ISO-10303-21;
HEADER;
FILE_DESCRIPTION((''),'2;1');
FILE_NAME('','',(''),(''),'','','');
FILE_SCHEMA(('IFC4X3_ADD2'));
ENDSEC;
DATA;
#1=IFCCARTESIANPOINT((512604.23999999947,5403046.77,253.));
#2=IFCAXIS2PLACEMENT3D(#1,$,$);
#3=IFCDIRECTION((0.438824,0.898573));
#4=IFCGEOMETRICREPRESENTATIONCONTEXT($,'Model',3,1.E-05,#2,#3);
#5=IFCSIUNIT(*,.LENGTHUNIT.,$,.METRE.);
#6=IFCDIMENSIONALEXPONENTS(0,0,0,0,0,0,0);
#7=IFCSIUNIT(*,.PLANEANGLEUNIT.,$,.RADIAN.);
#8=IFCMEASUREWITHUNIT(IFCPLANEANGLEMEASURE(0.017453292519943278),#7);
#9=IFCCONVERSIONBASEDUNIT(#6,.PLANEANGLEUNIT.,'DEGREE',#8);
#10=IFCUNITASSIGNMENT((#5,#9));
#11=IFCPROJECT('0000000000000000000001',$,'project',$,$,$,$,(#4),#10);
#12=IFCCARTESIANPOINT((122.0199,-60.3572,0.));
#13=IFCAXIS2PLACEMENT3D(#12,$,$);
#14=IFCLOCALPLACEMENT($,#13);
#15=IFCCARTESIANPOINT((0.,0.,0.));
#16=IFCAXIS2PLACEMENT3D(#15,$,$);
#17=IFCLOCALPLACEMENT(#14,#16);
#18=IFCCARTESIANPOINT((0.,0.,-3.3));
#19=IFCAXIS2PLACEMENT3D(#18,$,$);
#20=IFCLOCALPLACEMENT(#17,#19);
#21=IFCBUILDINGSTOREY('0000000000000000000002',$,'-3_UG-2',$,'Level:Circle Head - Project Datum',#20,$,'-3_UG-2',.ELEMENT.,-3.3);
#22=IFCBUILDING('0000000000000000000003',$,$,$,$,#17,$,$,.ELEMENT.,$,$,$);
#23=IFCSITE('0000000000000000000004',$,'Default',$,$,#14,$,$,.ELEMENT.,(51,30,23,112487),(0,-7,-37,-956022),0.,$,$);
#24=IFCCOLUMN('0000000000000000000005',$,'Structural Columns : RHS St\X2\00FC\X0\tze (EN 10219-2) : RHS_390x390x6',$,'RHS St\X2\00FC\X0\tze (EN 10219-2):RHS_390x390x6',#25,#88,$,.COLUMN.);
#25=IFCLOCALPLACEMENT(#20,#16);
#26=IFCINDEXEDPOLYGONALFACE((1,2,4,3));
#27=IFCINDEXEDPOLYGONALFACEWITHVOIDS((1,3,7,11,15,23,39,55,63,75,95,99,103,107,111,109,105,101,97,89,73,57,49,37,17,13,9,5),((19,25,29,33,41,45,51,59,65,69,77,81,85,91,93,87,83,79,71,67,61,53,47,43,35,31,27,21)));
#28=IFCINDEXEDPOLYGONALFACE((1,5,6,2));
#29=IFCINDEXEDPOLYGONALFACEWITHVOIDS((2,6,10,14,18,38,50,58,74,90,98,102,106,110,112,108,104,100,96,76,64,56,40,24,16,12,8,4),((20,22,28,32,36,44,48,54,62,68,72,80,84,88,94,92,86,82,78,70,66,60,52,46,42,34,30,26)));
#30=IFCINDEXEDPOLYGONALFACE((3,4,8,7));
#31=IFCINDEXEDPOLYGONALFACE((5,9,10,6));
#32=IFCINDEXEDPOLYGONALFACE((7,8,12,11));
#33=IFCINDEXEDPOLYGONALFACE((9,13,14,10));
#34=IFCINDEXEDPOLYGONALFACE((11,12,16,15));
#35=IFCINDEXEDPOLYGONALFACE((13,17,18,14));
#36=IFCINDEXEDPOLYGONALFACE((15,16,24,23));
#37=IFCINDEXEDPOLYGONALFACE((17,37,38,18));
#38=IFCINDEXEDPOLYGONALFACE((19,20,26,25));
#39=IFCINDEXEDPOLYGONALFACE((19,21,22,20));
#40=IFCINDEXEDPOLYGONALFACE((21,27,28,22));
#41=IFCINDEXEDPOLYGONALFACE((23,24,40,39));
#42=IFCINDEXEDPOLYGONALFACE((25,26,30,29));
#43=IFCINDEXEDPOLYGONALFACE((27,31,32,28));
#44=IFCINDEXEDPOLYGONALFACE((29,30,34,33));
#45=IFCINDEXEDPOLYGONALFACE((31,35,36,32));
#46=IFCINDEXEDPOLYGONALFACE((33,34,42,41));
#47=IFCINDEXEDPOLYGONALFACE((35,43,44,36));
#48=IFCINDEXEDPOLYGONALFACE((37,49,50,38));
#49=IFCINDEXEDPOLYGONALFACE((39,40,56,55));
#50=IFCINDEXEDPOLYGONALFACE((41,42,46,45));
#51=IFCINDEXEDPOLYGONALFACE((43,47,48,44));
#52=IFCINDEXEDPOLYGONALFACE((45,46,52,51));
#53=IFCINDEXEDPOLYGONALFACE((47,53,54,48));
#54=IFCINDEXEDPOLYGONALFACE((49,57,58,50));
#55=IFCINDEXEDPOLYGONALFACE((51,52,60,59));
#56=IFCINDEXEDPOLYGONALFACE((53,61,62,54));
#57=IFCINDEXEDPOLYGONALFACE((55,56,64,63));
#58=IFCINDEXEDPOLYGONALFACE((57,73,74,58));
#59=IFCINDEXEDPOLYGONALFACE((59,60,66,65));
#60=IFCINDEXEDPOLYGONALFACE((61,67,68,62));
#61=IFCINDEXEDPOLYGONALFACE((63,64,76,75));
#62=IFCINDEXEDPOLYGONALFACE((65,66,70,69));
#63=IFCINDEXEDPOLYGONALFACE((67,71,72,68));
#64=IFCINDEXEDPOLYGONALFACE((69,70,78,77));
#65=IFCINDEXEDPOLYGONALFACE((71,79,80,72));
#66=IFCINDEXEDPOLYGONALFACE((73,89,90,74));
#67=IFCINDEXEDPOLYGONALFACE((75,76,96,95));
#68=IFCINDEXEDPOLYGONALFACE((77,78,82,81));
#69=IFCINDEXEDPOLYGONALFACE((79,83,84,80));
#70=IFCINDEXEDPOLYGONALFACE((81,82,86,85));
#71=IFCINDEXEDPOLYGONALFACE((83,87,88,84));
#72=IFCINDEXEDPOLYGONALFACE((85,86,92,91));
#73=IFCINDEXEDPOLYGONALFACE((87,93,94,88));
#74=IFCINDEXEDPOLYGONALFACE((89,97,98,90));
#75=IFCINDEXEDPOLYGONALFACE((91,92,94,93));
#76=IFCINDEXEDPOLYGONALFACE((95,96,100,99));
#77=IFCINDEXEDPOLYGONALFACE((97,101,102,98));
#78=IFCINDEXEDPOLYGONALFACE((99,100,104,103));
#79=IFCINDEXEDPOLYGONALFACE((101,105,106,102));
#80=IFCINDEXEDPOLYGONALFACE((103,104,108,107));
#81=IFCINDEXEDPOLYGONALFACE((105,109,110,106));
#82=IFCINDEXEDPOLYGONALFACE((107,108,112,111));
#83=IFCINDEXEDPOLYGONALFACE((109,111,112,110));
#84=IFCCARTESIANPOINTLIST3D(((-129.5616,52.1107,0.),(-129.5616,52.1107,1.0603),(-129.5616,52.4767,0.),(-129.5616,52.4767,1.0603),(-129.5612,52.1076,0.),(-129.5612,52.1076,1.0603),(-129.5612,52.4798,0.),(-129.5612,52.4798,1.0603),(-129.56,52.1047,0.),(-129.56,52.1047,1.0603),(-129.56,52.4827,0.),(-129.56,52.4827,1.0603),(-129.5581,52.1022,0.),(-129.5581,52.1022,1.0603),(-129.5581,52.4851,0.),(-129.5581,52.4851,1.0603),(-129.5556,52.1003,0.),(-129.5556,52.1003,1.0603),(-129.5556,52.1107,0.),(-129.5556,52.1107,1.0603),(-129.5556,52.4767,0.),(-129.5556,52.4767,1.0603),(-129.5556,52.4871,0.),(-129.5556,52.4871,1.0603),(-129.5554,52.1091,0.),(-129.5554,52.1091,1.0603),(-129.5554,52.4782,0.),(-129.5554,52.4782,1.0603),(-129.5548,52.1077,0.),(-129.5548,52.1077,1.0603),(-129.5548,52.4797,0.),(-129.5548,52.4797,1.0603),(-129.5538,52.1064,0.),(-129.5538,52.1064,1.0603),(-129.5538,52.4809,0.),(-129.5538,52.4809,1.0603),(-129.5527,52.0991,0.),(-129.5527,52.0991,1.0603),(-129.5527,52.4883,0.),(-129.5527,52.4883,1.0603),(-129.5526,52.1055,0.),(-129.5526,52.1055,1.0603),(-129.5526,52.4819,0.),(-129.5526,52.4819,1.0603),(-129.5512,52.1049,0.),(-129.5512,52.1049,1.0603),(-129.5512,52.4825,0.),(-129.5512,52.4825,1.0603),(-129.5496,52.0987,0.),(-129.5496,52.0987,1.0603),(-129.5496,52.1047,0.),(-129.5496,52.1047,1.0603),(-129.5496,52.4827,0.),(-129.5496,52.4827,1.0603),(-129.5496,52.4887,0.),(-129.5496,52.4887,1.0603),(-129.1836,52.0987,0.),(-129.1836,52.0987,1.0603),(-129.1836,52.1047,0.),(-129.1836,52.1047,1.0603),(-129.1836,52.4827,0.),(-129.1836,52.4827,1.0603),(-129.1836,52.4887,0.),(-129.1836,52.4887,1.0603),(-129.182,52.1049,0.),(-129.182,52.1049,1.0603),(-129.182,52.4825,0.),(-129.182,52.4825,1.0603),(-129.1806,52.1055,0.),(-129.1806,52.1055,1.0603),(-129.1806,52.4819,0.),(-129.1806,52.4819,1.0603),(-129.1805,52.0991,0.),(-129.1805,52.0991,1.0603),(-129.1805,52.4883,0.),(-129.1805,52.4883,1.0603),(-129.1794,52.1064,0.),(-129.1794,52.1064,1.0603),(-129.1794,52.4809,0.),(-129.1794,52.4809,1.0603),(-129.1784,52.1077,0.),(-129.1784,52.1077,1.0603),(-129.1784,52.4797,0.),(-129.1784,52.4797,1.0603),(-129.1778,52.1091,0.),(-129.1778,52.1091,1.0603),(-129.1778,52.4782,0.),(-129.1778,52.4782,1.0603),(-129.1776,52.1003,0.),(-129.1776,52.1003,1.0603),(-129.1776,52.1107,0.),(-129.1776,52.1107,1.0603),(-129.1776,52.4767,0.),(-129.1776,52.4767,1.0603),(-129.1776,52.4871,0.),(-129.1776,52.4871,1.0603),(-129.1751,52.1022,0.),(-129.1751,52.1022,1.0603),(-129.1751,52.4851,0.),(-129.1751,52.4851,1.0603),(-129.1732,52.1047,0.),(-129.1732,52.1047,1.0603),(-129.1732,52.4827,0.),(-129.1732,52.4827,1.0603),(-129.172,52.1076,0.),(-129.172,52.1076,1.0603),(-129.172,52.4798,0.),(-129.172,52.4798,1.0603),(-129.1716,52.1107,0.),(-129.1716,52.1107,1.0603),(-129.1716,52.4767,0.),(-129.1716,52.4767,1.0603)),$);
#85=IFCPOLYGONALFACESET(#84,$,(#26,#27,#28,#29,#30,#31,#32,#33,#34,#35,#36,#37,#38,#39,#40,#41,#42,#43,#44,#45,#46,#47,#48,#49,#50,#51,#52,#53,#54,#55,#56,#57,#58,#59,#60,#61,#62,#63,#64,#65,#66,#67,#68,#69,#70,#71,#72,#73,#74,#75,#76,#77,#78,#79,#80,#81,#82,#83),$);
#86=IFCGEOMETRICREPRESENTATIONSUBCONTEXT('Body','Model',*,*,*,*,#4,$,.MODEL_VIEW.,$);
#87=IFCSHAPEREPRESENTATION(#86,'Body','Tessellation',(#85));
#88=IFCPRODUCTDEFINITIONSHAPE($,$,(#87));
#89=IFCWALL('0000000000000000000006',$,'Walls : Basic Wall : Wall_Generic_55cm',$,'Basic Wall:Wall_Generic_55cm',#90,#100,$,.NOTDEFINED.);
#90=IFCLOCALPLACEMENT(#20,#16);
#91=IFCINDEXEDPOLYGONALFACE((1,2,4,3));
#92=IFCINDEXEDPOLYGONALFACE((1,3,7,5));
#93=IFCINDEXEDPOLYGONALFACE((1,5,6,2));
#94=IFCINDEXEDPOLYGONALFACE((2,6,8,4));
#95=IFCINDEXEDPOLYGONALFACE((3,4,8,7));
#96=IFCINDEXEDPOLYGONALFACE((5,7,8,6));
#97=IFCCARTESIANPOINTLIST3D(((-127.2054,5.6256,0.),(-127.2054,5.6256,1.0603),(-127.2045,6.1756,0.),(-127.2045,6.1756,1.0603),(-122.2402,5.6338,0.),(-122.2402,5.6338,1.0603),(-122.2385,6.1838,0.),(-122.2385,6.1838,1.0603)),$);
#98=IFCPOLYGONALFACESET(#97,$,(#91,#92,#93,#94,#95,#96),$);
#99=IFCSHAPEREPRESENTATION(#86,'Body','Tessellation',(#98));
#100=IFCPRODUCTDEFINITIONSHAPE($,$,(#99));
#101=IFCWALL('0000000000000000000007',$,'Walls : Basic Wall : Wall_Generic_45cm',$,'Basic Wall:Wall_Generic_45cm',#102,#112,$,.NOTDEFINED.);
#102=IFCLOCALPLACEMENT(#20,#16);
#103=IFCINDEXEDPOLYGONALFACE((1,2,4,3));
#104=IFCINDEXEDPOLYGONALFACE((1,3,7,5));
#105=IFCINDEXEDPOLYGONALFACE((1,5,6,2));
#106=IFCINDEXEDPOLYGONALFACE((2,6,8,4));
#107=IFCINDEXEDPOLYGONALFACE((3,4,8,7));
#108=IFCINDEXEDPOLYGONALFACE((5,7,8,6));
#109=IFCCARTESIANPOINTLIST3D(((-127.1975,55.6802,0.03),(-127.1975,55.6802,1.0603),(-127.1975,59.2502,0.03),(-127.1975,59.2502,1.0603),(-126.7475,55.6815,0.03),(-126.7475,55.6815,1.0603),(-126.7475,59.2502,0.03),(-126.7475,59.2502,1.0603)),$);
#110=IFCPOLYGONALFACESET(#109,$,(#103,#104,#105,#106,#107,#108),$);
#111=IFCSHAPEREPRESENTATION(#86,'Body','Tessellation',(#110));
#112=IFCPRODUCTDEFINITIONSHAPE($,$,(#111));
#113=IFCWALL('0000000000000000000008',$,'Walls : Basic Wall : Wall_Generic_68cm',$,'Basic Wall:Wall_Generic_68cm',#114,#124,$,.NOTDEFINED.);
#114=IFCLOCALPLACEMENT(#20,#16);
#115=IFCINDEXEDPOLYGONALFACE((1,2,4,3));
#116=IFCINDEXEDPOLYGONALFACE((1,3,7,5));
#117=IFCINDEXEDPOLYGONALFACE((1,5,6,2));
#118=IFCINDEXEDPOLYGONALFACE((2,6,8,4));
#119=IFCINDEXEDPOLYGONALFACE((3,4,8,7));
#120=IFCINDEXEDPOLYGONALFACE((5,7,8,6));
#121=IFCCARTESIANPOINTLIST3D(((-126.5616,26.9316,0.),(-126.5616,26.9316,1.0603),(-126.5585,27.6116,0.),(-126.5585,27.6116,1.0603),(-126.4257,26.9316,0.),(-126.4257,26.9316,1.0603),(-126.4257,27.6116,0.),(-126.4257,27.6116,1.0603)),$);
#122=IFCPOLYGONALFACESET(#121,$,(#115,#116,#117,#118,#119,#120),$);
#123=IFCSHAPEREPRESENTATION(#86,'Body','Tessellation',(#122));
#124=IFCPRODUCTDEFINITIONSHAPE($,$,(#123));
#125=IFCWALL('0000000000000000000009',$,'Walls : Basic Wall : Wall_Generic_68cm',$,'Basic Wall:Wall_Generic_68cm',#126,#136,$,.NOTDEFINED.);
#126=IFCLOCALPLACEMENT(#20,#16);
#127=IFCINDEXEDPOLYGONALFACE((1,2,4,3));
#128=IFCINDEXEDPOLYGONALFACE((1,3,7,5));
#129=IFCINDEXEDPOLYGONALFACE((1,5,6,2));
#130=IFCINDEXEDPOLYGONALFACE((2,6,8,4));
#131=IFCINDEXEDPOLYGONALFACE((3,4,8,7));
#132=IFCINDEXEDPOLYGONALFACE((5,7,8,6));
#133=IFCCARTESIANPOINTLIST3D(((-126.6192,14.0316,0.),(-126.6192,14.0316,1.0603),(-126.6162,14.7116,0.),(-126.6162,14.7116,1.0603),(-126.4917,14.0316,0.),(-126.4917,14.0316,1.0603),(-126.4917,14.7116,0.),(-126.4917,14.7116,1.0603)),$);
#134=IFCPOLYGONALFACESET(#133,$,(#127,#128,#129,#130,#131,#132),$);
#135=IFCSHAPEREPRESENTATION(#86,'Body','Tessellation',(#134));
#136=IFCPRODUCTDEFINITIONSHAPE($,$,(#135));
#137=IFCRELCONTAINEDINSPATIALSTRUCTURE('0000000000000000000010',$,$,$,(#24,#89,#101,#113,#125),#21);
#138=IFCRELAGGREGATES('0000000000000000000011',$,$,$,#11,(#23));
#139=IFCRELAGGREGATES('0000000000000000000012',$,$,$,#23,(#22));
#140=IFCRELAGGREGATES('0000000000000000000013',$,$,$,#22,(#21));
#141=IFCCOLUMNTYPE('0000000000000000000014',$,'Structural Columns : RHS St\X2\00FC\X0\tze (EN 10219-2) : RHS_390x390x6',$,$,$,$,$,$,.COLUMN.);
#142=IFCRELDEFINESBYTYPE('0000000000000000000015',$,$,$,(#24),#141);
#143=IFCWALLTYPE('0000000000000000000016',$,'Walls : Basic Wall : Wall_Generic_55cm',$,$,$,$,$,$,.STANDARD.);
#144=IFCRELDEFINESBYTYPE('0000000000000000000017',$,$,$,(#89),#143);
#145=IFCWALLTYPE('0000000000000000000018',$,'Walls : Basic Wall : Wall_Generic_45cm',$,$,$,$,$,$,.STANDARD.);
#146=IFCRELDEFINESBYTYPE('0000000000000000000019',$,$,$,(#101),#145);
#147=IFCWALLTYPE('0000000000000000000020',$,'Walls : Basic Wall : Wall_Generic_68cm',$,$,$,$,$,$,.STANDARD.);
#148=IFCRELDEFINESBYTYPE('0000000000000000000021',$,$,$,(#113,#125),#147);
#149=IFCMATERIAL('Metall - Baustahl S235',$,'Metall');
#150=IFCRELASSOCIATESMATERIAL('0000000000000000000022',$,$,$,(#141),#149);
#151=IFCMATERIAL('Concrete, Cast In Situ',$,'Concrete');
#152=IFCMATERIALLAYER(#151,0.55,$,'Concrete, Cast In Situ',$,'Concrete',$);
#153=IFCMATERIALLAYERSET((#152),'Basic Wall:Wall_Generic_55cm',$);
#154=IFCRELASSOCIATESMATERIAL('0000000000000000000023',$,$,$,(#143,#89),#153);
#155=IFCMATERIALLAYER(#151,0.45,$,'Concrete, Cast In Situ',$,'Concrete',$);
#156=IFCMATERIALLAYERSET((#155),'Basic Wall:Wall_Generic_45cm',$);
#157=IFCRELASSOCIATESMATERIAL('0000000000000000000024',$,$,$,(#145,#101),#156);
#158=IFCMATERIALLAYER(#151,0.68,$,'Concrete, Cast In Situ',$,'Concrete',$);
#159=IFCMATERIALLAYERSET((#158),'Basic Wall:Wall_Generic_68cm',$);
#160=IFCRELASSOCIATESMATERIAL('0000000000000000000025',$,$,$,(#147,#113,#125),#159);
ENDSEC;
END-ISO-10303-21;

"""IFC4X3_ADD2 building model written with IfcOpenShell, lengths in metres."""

from ifc_helpers import new_model, entity, si_unit, converted_unit, direction, frame, frame_2d, origin, place, context, subcontext, project, spatial, polyline, circle_curve, parameter, trimmed, segment, composite_curve, outline, extrude, clip, halfspace, source, transform, mapped, material, layer, layer_set, material_profile, profile_set, type_object, type_shapes, element, save


model = new_model("IFC4X3_ADD2")

# Units and contexts
model_context = context("Model", 3, precision=1e-05, world=frame((512604.23999999947, 5403046.77, 253.0)), true_north=direction((0.438824, 0.898573)))
body_context = subcontext(model_context, "Body", "Model", "MODEL_VIEW")
ifc_project = project(units=[si_unit("LENGTHUNIT", "METRE"), converted_unit("PLANEANGLEUNIT", "DEGREE", entity("IfcPlaneAngleMeasure", 0.017453292519943278), si_unit("PLANEANGLEUNIT", "RADIAN"), dimensions=[0, 0, 0, 0, 0, 0, 0])], contexts=[model_context])

# Site, building, storey
site_placement = place(None, frame((122.0199, -60.3572, 0.0)))
site = spatial("IfcSite", under=ifc_project, at=site_placement, Name="Default", CompositionType="ELEMENT", RefLatitude=(51, 30, 23, 112487), RefLongitude=(0, -7, -37, -956022), RefElevation=0.0)
building_placement = place(site_placement, origin())
building = spatial("IfcBuilding", under=site, at=building_placement, CompositionType="ELEMENT")
storey_placement = place(building_placement, frame((0.0, 0.0, -3.3)))
storey = spatial("IfcBuildingStorey", under=building, at=storey_placement, Name="-3_UG-2", ObjectType="Level:Circle Head - Project Datum", LongName="-3_UG-2", CompositionType="ELEMENT", Elevation=-3.3)

# Column
ifc_material_1 = material(Name="Metall - Baustahl S235", Category="Metall")
ifc_material_profile_1 = material_profile(ifc_material_1, outline(composite_curve([segment(polyline([(-0.183, -0.195), (0.183, -0.195)]), True, "CONTINUOUS"), segment(trimmed(circle_curve(frame_2d((0.183, -0.183), x_axis=(-1.0, 0.0)), 0.012), [parameter(90.0)], [parameter(180.0)], True, "PARAMETER"), True, "CONTINUOUS"), segment(polyline([(0.195, -0.183), (0.195, 0.183)]), True, "CONTINUOUS"), segment(trimmed(circle_curve(frame_2d((0.183, 0.183), x_axis=(-1.0, 0.0)), 0.012), [parameter(180.0)], [parameter(270.0)], True, "PARAMETER"), True, "CONTINUOUS"), segment(polyline([(0.183, 0.195), (-0.183, 0.195)]), True, "CONTINUOUS"), segment(trimmed(circle_curve(frame_2d((-0.183, 0.183), x_axis=(-1.0, 0.0)), 0.012), [parameter(270.0)], [parameter(360.0)], True, "PARAMETER"), True, "CONTINUOUS"), segment(polyline([(-0.195, 0.183), (-0.195, -0.183)]), True, "CONTINUOUS"), segment(trimmed(circle_curve(frame_2d((-0.183, -0.183), x_axis=(-1.0, 0.0)), 0.012), [parameter(360.0)], [parameter(90.0)], True, "PARAMETER"), True, "CONTINUOUS")], self_intersect=False), holes=[composite_curve([segment(trimmed(circle_curve(frame_2d((-0.183, -0.183), x_axis=(-1.0, 0.0)), 0.006), [parameter(0.0)], [parameter(90.0)], True, "PARAMETER"), False, "CONTINUOUS"), segment(polyline([(-0.189, -0.183), (-0.189, 0.183)]), True, "CONTINUOUS"), segment(trimmed(circle_curve(frame_2d((-0.183, 0.183), x_axis=(-1.0, 0.0)), 0.006), [parameter(270.0)], [parameter(0.0)], True, "PARAMETER"), False, "CONTINUOUS"), segment(polyline([(-0.183, 0.189), (0.183, 0.189)]), True, "CONTINUOUS"), segment(trimmed(circle_curve(frame_2d((0.183, 0.183), x_axis=(-1.0, 0.0)), 0.006), [parameter(180.0)], [parameter(270.0)], True, "PARAMETER"), False, "CONTINUOUS"), segment(polyline([(0.189, 0.183), (0.189, -0.183)]), True, "CONTINUOUS"), segment(trimmed(circle_curve(frame_2d((0.183, -0.183), x_axis=(-1.0, 0.0)), 0.006), [parameter(90.0)], [parameter(180.0)], True, "PARAMETER"), False, "CONTINUOUS"), segment(polyline([(0.183, -0.189), (-0.183, -0.189)]), True, "CONTINUOUS")], self_intersect=False)]), Name="RHS_390x390x6")
ifc_profile_set_1 = profile_set([ifc_material_profile_1], Name="RHS_390x390x6")
column_type_1 = type_object("IfcColumnType", Name="Structural Columns : RHS Stütze (EN 10219-2) : RHS_390x390x6", PredefinedType="COLUMN", material=ifc_profile_set_1)
shared_shape_1 = source(origin(), body_context, "Body", "SweptSolid", [
    extrude(outline(composite_curve([segment(polyline([(-0.183, -0.195), (0.183, -0.195)]), True, "CONTINUOUS"), segment(trimmed(circle_curve(frame_2d((0.183, -0.183), x_axis=(-1.0, 0.0)), 0.012), [parameter(90.0)], [parameter(180.0)], True, "PARAMETER"), True, "CONTINUOUS"), segment(polyline([(0.195, -0.183), (0.195, 0.183)]), True, "CONTINUOUS"), segment(trimmed(circle_curve(frame_2d((0.183, 0.183), x_axis=(-1.0, 0.0)), 0.012), [parameter(180.0)], [parameter(270.0)], True, "PARAMETER"), True, "CONTINUOUS"), segment(polyline([(0.183, 0.195), (-0.183, 0.195)]), True, "CONTINUOUS"), segment(trimmed(circle_curve(frame_2d((-0.183, 0.183), x_axis=(-1.0, 0.0)), 0.012), [parameter(270.0)], [parameter(360.0)], True, "PARAMETER"), True, "CONTINUOUS"), segment(polyline([(-0.195, 0.183), (-0.195, -0.183)]), True, "CONTINUOUS"), segment(trimmed(circle_curve(frame_2d((-0.183, -0.183), x_axis=(-1.0, 0.0)), 0.012), [parameter(360.0)], [parameter(90.0)], True, "PARAMETER"), True, "CONTINUOUS")], self_intersect=False), holes=[composite_curve([segment(trimmed(circle_curve(frame_2d((-0.183, -0.183), x_axis=(-1.0, 0.0)), 0.006), [parameter(0.0)], [parameter(90.0)], True, "PARAMETER"), False, "CONTINUOUS"), segment(polyline([(-0.189, -0.183), (-0.189, 0.183)]), True, "CONTINUOUS"), segment(trimmed(circle_curve(frame_2d((-0.183, 0.183), x_axis=(-1.0, 0.0)), 0.006), [parameter(270.0)], [parameter(0.0)], True, "PARAMETER"), False, "CONTINUOUS"), segment(polyline([(-0.183, 0.189), (0.183, 0.189)]), True, "CONTINUOUS"), segment(trimmed(circle_curve(frame_2d((0.183, 0.183), x_axis=(-1.0, 0.0)), 0.006), [parameter(180.0)], [parameter(270.0)], True, "PARAMETER"), False, "CONTINUOUS"), segment(polyline([(0.189, 0.183), (0.189, -0.183)]), True, "CONTINUOUS"), segment(trimmed(circle_curve(frame_2d((0.183, -0.183), x_axis=(-1.0, 0.0)), 0.006), [parameter(90.0)], [parameter(180.0)], True, "PARAMETER"), False, "CONTINUOUS"), segment(polyline([(0.183, -0.189), (-0.183, -0.189)]), True, "CONTINUOUS")], self_intersect=False)]), frame((0.0, 0.0, -3.3), z_axis=(0.0, 0.0, 1.0), x_axis=(-1.0, 0.0, 0.0)), (0.0, 0.0, 1.0), 1.0603),
])
type_shapes(column_type_1, [shared_shape_1])
column_1_placement = place(storey_placement, frame((-129.3666, 52.2937, 3.3)))
element("IfcColumn", 1, at=column_1_placement, inside=storey, type_object=column_type_1, Name="Structural Columns : RHS Stütze (EN 10219-2) : RHS_390x390x6", ObjectType="RHS Stütze (EN 10219-2):RHS_390x390x6", PredefinedType="COLUMN", context=body_context, shape_type="MappedRepresentation", body=[
    mapped(shared_shape_1, transform((0.0, 0.0, 0.0), scale=1.0)),
])

# Walls
ifc_material_2 = material(Name="Concrete, Cast In Situ", Category="Concrete")
ifc_layer_1 = layer(ifc_material_2, 0.55, Name="Concrete, Cast In Situ", Category="Concrete")
ifc_layer_set_1 = layer_set([ifc_layer_1], Name="Basic Wall:Wall_Generic_55cm")
wall_type_1 = type_object("IfcWallType", Name="Walls : Basic Wall : Wall_Generic_55cm", PredefinedType="STANDARD", material=ifc_layer_set_1)
wall_1_placement = place(storey_placement, frame((-127.2058, 5.9006, 0.0), z_axis=(0.0, 0.0, 1.0), x_axis=(0.999999, 0.001649, 0.0)))
element("IfcWall", 2, at=wall_1_placement, inside=storey, type_object=wall_type_1, material=ifc_layer_set_1, Name="Walls : Basic Wall : Wall_Generic_55cm", ObjectType="Basic Wall:Wall_Generic_55cm", PredefinedType="NOTDEFINED", context=body_context, shape_type="Clipping", body=[
    clip(extrude(outline(polyline([(4.9652, -0.275), (4.9678, 0.275), (0.3368, 0.275), (0.0017, 0.275), (0.0, -0.275), (4.9652, -0.275)])), origin(), (0.0, 0.0, 1.0), 1.0603), halfspace(origin(), True)),
])
ifc_layer_2 = layer(ifc_material_2, 0.45, Name="Concrete, Cast In Situ", Category="Concrete")
ifc_layer_set_2 = layer_set([ifc_layer_2], Name="Basic Wall:Wall_Generic_45cm")
wall_type_2 = type_object("IfcWallType", Name="Walls : Basic Wall : Wall_Generic_45cm", PredefinedType="STANDARD", material=ifc_layer_set_2)
wall_2_placement = place(storey_placement, frame((-126.9725, 59.2502, 0.03), z_axis=(0.0, 0.0, 1.0), x_axis=(0.0, -1.0, 0.0)))
element("IfcWall", 3, at=wall_2_placement, inside=storey, type_object=wall_type_2, material=ifc_layer_set_2, Name="Walls : Basic Wall : Wall_Generic_45cm", ObjectType="Basic Wall:Wall_Generic_45cm", PredefinedType="NOTDEFINED", context=body_context, shape_type="Clipping", body=[
    clip(extrude(outline(polyline([(3.5701, -0.225), (3.5687, 0.225), (0.0, 0.225), (0.0, -0.225), (3.5701, -0.225)])), origin(), (0.0, 0.0, 1.0), 1.0303), halfspace(origin(), True)),
])
ifc_layer_3 = layer(ifc_material_2, 0.68, Name="Concrete, Cast In Situ", Category="Concrete")
ifc_layer_set_3 = layer_set([ifc_layer_3], Name="Basic Wall:Wall_Generic_68cm")
wall_type_3 = type_object("IfcWallType", Name="Walls : Basic Wall : Wall_Generic_68cm", PredefinedType="STANDARD", material=ifc_layer_set_3)
wall_3_placement = place(storey_placement, frame((-126.5616, 27.2716, 0.0)))
element("IfcWall", 4, at=wall_3_placement, inside=storey, type_object=wall_type_3, material=ifc_layer_set_3, Name="Walls : Basic Wall : Wall_Generic_68cm", ObjectType="Basic Wall:Wall_Generic_68cm", PredefinedType="NOTDEFINED", context=body_context, shape_type="Clipping", body=[
    clip(extrude(outline(polyline([(0.1359, -0.34), (0.1359, 0.34), (0.003, 0.34), (0.0, -0.34), (0.1359, -0.34)])), origin(), (0.0, 0.0, 1.0), 1.0603), halfspace(origin(), True)),
])
wall_4_placement = place(storey_placement, frame((-126.6192, 14.3716, 0.0)))
element("IfcWall", 5, at=wall_4_placement, inside=storey, type_object=wall_type_3, material=ifc_layer_set_3, Name="Walls : Basic Wall : Wall_Generic_68cm", ObjectType="Basic Wall:Wall_Generic_68cm", PredefinedType="NOTDEFINED", context=body_context, shape_type="Clipping", body=[
    clip(extrude(outline(polyline([(0.1275, -0.34), (0.1275, 0.34), (0.003, 0.34), (0.0, -0.34), (0.1275, -0.34)])), origin(), (0.0, 0.0, 1.0), 1.0603), halfspace(origin(), True)),
])

save(model, "model.ifc")
